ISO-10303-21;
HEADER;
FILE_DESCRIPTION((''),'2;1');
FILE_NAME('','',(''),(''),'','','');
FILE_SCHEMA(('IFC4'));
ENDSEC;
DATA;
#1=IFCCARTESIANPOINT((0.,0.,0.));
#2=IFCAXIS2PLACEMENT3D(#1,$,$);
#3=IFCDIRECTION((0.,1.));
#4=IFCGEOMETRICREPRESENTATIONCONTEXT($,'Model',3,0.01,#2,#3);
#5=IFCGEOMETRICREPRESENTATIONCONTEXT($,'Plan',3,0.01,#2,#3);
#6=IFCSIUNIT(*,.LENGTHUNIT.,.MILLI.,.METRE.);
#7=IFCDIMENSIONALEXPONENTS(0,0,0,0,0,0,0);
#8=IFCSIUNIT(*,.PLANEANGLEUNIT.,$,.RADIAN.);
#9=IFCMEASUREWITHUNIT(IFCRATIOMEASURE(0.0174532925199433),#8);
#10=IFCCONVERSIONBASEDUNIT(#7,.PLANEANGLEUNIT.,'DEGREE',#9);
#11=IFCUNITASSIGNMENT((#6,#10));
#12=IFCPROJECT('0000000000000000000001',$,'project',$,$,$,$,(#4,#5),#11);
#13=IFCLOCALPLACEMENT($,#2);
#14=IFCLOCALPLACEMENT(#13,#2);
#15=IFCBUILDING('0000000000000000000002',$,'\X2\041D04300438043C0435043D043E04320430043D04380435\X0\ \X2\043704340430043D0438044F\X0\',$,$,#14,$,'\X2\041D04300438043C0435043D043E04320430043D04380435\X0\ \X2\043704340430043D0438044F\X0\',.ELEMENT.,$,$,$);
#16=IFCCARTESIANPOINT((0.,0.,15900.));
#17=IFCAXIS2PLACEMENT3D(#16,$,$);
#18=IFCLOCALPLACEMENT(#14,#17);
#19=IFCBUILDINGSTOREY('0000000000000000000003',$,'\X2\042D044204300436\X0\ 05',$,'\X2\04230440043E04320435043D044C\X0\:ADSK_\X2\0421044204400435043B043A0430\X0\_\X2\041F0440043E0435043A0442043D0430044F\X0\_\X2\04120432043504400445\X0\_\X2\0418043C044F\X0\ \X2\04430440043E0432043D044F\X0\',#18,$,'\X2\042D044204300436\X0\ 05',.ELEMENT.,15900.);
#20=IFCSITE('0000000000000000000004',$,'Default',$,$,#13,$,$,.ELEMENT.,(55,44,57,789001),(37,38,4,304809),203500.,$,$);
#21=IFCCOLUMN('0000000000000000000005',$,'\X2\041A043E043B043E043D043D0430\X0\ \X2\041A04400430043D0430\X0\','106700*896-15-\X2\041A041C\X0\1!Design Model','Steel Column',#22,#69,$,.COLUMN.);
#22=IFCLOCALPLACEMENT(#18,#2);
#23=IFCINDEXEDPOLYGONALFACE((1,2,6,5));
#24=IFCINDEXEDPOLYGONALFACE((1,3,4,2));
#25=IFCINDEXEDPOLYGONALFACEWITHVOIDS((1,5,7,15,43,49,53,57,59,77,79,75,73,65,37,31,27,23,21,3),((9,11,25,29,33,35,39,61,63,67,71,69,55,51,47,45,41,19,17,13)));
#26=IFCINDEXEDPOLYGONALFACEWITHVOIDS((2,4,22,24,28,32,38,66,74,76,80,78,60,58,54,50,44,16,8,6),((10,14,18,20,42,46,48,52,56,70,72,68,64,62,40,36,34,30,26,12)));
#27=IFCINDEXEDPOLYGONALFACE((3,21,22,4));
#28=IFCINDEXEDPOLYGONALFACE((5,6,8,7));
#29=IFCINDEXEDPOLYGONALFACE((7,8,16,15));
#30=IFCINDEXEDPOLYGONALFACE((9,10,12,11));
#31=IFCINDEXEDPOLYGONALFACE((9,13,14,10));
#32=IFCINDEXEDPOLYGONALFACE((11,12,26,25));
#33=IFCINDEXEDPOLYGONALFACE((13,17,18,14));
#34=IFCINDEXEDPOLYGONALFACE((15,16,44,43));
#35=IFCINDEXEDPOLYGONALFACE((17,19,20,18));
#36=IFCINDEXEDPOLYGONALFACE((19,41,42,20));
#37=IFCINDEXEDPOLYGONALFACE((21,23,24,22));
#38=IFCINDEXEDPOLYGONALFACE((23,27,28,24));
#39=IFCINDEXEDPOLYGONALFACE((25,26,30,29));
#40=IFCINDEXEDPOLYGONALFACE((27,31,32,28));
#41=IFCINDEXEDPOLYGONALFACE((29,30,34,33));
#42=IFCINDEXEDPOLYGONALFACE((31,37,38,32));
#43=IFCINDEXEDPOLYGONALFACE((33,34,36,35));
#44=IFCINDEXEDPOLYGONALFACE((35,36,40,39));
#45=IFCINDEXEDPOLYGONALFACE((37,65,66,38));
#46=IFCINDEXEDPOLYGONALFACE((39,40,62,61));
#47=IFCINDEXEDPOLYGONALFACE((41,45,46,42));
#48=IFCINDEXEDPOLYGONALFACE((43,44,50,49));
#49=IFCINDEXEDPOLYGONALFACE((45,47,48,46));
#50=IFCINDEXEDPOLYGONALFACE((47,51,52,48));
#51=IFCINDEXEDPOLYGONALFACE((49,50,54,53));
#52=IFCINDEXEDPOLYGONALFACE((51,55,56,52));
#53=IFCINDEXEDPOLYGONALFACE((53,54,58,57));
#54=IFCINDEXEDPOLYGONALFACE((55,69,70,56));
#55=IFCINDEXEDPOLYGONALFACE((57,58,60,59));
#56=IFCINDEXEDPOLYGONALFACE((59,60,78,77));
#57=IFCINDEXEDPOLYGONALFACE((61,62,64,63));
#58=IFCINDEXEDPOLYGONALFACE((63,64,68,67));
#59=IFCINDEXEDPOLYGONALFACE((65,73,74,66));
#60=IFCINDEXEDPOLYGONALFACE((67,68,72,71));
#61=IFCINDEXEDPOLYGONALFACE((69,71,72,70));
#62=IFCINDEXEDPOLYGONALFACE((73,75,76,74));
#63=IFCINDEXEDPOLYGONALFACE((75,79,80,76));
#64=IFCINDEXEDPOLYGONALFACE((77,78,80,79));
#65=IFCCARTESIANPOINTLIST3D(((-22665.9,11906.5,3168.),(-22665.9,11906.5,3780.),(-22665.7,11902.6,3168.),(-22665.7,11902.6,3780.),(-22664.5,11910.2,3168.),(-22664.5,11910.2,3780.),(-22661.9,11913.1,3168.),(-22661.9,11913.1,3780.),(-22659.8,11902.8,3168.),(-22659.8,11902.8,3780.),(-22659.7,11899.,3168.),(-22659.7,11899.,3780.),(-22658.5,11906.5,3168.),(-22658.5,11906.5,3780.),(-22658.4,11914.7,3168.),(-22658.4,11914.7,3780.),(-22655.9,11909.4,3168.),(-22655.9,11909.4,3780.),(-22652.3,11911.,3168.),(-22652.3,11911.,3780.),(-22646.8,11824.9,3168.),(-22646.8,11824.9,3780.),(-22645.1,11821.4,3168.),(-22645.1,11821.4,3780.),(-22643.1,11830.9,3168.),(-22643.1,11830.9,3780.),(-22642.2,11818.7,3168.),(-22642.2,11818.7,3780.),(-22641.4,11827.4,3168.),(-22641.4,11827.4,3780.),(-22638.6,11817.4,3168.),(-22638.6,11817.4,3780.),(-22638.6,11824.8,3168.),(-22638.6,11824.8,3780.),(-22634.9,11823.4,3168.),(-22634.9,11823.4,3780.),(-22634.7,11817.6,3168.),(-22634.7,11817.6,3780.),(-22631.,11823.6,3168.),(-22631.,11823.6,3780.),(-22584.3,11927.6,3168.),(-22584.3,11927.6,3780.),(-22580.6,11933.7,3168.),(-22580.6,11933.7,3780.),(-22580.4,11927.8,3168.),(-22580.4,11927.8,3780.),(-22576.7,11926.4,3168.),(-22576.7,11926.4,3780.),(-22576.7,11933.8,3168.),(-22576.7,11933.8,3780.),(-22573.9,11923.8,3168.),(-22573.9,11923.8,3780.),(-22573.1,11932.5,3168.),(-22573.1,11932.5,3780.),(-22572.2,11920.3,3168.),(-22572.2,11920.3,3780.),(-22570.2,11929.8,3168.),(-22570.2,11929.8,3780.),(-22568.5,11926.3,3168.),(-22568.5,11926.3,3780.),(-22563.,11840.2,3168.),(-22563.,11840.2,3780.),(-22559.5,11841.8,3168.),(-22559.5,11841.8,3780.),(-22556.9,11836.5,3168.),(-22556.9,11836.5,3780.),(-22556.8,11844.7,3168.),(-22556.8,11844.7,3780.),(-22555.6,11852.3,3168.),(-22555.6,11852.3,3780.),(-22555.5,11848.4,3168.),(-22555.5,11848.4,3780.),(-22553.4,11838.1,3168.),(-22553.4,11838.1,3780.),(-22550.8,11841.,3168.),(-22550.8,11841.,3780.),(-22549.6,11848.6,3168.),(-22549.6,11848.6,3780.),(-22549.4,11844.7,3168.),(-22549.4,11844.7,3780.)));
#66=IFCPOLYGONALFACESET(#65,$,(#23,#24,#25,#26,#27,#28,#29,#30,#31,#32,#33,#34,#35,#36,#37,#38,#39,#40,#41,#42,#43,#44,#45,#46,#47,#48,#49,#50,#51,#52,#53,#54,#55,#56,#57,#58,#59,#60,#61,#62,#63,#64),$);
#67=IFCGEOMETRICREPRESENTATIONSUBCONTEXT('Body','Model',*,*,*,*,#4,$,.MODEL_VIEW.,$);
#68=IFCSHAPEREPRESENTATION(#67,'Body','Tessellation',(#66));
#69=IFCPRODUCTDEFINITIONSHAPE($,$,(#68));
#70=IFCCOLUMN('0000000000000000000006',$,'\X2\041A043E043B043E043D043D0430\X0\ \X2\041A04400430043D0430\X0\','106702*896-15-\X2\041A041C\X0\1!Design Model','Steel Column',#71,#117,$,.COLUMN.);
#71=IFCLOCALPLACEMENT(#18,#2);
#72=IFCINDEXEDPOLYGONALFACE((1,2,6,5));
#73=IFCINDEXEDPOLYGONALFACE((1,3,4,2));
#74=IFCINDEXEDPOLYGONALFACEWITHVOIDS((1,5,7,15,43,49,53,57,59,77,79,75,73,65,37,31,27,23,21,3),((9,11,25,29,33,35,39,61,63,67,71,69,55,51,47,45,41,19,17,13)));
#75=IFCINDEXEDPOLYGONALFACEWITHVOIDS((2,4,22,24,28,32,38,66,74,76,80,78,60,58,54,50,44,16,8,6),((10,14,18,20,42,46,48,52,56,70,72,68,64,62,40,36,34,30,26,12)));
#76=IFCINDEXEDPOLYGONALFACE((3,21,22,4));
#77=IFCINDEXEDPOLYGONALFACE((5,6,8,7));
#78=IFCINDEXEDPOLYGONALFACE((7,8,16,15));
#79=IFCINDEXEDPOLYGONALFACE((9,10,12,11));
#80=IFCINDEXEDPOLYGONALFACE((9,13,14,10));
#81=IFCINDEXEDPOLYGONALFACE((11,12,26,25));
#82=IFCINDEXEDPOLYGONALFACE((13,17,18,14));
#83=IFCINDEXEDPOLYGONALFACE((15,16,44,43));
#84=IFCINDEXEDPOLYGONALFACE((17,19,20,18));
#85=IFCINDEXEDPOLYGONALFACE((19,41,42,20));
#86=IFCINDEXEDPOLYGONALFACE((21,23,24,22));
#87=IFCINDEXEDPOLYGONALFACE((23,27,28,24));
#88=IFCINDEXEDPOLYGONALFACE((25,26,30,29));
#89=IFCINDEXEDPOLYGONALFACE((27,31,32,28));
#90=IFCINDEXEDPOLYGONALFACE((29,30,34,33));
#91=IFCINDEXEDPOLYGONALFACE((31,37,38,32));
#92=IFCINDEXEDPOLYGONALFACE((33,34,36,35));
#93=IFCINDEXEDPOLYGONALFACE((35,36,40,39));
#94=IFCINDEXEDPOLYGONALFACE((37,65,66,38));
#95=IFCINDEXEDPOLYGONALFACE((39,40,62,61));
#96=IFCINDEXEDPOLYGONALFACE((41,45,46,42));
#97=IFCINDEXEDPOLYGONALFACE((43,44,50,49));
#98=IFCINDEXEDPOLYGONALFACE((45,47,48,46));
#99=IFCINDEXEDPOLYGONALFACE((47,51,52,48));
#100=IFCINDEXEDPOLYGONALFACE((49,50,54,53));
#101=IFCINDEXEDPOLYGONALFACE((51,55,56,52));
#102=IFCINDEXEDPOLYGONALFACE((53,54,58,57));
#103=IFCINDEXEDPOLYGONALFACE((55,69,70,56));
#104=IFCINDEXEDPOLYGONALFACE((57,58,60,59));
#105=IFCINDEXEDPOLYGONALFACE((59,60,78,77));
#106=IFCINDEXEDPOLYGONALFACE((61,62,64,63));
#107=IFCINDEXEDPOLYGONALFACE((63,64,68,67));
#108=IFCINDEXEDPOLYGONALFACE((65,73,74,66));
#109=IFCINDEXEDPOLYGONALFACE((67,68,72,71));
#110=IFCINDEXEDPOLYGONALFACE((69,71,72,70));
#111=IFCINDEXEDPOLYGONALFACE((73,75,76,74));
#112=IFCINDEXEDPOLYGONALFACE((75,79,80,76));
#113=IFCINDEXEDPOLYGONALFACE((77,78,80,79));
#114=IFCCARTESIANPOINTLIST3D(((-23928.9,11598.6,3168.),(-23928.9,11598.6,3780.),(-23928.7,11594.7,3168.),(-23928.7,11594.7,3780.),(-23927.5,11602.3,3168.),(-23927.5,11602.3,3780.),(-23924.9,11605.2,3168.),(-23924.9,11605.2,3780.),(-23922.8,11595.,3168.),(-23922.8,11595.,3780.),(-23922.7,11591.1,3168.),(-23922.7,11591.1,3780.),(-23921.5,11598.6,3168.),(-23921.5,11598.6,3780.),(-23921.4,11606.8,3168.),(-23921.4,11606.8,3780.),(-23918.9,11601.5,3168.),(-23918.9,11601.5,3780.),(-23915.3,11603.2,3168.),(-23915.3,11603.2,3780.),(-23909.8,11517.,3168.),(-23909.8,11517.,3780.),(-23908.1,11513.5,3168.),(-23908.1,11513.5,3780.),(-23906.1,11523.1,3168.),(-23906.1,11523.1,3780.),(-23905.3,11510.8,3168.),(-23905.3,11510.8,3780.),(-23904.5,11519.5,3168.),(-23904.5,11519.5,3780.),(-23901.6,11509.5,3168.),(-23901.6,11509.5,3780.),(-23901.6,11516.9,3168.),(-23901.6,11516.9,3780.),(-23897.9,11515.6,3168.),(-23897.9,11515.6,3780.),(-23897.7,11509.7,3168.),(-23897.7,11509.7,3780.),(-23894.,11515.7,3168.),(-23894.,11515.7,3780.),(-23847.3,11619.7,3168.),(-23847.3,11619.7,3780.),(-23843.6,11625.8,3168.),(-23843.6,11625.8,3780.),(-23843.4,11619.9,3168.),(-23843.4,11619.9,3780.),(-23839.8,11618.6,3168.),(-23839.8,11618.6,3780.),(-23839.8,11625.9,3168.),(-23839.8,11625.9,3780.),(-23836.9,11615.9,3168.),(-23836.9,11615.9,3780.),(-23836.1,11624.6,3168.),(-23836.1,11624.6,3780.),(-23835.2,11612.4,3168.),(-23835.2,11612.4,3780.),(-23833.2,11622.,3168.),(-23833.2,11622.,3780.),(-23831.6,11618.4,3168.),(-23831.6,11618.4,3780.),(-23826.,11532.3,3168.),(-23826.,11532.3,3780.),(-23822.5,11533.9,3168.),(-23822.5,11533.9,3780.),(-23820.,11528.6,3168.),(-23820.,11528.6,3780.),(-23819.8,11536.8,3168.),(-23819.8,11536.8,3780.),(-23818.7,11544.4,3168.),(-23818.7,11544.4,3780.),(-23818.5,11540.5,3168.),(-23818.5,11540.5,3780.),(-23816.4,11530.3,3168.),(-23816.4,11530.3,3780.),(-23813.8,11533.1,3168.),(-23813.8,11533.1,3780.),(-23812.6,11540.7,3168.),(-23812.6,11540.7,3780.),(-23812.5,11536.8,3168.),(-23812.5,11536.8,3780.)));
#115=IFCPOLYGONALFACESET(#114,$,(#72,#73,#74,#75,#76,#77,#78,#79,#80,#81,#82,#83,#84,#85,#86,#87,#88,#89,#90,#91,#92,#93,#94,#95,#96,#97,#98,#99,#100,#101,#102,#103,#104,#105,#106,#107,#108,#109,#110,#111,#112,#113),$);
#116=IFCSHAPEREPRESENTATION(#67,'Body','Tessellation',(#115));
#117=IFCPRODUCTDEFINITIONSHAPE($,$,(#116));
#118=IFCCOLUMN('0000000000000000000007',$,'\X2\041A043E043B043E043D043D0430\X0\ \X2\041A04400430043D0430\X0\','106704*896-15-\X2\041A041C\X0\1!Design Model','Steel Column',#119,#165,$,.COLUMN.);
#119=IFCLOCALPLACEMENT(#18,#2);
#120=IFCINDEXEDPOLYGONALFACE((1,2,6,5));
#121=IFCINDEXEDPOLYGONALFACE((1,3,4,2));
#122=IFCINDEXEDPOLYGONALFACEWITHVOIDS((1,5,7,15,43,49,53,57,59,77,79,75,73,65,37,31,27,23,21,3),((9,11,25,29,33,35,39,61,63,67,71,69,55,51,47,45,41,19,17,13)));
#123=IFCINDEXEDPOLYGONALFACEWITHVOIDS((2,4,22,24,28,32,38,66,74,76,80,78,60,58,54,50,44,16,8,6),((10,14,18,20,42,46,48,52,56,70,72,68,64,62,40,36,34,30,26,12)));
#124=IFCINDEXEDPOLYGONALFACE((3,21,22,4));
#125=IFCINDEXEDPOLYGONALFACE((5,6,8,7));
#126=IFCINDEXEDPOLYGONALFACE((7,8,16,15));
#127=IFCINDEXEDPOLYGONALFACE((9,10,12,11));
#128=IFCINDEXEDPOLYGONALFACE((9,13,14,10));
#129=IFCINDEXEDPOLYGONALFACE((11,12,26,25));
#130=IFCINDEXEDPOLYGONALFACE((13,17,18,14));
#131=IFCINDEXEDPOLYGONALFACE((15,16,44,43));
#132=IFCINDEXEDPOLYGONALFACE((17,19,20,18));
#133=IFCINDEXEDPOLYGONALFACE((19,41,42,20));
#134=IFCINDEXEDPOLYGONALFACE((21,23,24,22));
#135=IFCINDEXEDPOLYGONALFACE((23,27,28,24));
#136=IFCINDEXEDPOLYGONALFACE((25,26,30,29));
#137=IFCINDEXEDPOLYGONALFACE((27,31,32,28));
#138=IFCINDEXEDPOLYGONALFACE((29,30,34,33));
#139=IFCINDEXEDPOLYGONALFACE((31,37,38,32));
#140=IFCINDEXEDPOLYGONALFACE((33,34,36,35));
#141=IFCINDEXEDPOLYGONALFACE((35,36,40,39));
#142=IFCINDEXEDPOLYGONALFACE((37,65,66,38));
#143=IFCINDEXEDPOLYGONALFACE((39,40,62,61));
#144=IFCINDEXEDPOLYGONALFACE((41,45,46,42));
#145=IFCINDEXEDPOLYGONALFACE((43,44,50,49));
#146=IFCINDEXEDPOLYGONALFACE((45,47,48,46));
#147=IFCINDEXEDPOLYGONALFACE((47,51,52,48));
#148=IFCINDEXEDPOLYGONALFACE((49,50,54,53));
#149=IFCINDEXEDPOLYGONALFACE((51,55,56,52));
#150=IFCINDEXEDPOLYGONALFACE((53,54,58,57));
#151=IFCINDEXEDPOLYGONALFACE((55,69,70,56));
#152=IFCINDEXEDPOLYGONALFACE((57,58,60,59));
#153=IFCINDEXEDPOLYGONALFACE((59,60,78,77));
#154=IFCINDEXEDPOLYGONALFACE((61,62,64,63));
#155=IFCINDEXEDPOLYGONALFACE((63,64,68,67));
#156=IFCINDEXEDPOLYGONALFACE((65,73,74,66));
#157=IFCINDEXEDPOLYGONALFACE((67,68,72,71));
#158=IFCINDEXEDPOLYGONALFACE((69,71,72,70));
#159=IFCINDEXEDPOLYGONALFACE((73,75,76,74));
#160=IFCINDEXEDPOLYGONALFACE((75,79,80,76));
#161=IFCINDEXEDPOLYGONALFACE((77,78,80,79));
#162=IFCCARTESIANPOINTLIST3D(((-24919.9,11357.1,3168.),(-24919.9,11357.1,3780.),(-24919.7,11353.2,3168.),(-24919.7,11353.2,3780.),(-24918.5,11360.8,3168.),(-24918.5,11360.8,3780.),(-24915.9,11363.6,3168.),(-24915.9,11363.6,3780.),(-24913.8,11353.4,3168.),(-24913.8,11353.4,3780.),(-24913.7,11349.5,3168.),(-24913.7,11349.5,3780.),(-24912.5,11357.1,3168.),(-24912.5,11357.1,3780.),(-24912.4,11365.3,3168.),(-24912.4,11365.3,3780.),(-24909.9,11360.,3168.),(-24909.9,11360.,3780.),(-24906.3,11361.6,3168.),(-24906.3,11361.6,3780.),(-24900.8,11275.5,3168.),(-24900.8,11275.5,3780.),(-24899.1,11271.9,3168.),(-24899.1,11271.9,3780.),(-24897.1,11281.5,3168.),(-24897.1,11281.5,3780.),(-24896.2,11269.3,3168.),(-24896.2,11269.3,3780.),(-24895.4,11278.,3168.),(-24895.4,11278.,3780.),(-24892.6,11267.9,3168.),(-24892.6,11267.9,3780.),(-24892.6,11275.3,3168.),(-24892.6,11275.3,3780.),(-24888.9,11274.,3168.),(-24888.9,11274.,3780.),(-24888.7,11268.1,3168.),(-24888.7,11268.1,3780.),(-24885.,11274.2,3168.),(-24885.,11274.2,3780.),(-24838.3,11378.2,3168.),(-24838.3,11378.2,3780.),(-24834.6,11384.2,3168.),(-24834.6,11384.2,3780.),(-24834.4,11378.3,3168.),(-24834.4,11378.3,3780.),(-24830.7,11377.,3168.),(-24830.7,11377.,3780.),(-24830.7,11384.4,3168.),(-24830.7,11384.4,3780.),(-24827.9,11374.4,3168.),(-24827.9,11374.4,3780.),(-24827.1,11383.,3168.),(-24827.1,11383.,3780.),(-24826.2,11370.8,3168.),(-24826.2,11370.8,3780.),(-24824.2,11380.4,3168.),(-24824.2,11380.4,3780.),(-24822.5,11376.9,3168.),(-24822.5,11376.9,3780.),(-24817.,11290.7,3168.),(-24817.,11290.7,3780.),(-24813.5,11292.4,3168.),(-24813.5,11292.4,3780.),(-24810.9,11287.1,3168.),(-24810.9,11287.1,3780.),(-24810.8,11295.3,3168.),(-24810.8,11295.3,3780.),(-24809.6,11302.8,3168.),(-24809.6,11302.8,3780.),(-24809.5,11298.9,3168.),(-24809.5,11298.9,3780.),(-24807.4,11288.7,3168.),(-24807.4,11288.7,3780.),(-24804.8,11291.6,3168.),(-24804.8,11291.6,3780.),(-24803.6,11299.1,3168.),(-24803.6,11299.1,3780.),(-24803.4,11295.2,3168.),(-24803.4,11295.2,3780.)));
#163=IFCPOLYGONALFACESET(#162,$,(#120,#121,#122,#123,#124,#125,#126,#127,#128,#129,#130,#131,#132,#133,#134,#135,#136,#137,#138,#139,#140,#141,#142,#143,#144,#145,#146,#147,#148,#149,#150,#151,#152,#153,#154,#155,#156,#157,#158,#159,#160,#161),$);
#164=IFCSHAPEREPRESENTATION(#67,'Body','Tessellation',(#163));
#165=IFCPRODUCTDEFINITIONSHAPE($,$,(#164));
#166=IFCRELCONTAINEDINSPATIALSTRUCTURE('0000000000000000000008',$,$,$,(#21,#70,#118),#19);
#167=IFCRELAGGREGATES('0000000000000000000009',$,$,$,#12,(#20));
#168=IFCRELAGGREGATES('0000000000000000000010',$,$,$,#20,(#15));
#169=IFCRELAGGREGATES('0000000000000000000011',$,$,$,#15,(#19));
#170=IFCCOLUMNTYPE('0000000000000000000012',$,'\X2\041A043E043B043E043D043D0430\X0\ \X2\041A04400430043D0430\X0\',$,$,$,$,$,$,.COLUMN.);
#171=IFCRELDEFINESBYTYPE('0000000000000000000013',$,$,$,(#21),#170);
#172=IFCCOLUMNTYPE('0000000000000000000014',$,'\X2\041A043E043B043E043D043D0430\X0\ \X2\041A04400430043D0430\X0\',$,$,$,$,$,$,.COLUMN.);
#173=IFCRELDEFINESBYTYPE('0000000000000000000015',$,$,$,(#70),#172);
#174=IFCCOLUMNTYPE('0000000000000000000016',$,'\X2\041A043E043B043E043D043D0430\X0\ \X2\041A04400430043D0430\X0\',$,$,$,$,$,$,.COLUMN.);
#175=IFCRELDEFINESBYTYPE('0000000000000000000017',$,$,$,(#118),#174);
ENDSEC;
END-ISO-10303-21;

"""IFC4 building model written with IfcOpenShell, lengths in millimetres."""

from ifc_helpers import new_model, entity, si_unit, converted_unit, direction, frame, origin, place, context, subcontext, project, spatial, indexed_curve, outline, extrude, type_object, element, save


model = new_model("IFC4")

# Units and contexts
model_context = context("Model", 3, precision=0.01, world=origin(), true_north=direction((0.0, 1.0)))
plan_context = context("Plan", 3, precision=0.01, world=origin(), true_north=direction((0.0, 1.0)))
body_context = subcontext(model_context, "Body", "Model", "MODEL_VIEW")
ifc_project = project(units=[si_unit("LENGTHUNIT", "METRE", prefix="MILLI"), converted_unit("PLANEANGLEUNIT", "DEGREE", entity("IfcRatioMeasure", 0.0174532925199433), si_unit("PLANEANGLEUNIT", "RADIAN"), dimensions=[0, 0, 0, 0, 0, 0, 0])], contexts=[model_context, plan_context])

# Site, building, storey
site_placement = place(None, origin())
site = spatial("IfcSite", under=ifc_project, at=site_placement, Name="Default", CompositionType="ELEMENT", RefLatitude=(55, 44, 57, 789001), RefLongitude=(37, 38, 4, 304809), RefElevation=203500.0)
building_placement = place(site_placement, origin())
building = spatial("IfcBuilding", under=site, at=building_placement, Name="Наименование здания", LongName="Наименование здания", CompositionType="ELEMENT")
storey_placement = place(building_placement, frame((0.0, 0.0, 15900.0)))
storey = spatial("IfcBuildingStorey", under=building, at=storey_placement, Name="Этаж 05", ObjectType="Уровень:ADSK_Стрелка_Проектная_Вверх_Имя уровня", LongName="Этаж 05", CompositionType="ELEMENT", Elevation=15900.0)

# Columns
column_type_1 = type_object("IfcColumnType", Name="Колонна Крана", PredefinedType="COLUMN")
column_1_placement = place(storey_placement, origin())
element("IfcColumn", 1, at=column_1_placement, inside=storey, type_object=column_type_1, Name="Колонна Крана", Description="106700*896-15-КМ1!Design Model", ObjectType="Steel Column", PredefinedType="COLUMN", context=body_context, shape_type="SweptSolid", body=[
    extrude(outline(indexed_curve([(29.5, -56.8), (33.4, -56.8), (37.0, -55.3), (39.7, -52.6), (41.2, -49.0), (56.8, 29.5), (56.8, 33.4), (55.3, 37.0), (52.6, 39.7), (49.0, 41.2), (-29.5, 56.8), (-33.4, 56.8), (-37.0, 55.3), (-39.7, 52.6), (-41.2, 49.0), (-56.8, -29.5), (-56.8, -33.4), (-55.3, -37.0), (-52.6, -39.7), (-49.0, -41.2), (29.5, -56.8)], self_intersect=False), holes=[indexed_curve([(-43.1, -37.3), (-46.7, -35.8), (-49.5, -33.1), (-51.0, -29.5), (-51.0, -25.5), (-37.3, 43.1), (-35.8, 46.7), (-33.1, 49.5), (-29.5, 51.0), (-25.5, 51.0), (43.1, 37.3), (46.7, 35.8), (49.5, 33.1), (51.0, 29.5), (51.0, 25.5), (37.3, -43.1), (35.8, -46.7), (33.1, -49.5), (29.5, -51.0), (25.5, -51.0), (-43.1, -37.3)], self_intersect=False)]), frame((-22607.7, 11875.6, 3168.0), z_axis=(0.0, 0.0, 1.0), x_axis=(-0.906681, -0.421816, 0.0)), (0.0, 0.0, 1.0), 612.0),
])
column_type_2 = type_object("IfcColumnType", Name="Колонна Крана", PredefinedType="COLUMN")
column_2_placement = place(storey_placement, origin())
element("IfcColumn", 2, at=column_2_placement, inside=storey, type_object=column_type_2, Name="Колонна Крана", Description="106702*896-15-КМ1!Design Model", ObjectType="Steel Column", PredefinedType="COLUMN", context=body_context, shape_type="SweptSolid", body=[
    extrude(outline(indexed_curve([(29.5, -56.8), (33.4, -56.8), (37.0, -55.3), (39.7, -52.6), (41.2, -49.0), (56.8, 29.5), (56.8, 33.4), (55.3, 37.0), (52.6, 39.7), (49.0, 41.2), (-29.5, 56.8), (-33.4, 56.8), (-37.0, 55.3), (-39.7, 52.6), (-41.2, 49.0), (-56.8, -29.5), (-56.8, -33.4), (-55.3, -37.0), (-52.6, -39.7), (-49.0, -41.2), (29.5, -56.8)], self_intersect=False), holes=[indexed_curve([(-43.1, -37.3), (-46.7, -35.8), (-49.5, -33.1), (-51.0, -29.5), (-51.0, -25.5), (-37.3, 43.1), (-35.8, 46.7), (-33.1, 49.5), (-29.5, 51.0), (-25.5, 51.0), (43.1, 37.3), (46.7, 35.8), (49.5, 33.1), (51.0, 29.5), (51.0, 25.5), (37.3, -43.1), (35.8, -46.7), (33.1, -49.5), (29.5, -51.0), (25.5, -51.0), (-43.1, -37.3)], self_intersect=False)]), frame((-23870.7, 11567.7, 3168.0), z_axis=(0.0, 0.0, 1.0), x_axis=(-0.906681, -0.421816, 0.0)), (0.0, 0.0, 1.0), 612.0),
])
column_type_3 = type_object("IfcColumnType", Name="Колонна Крана", PredefinedType="COLUMN")
column_3_placement = place(storey_placement, origin())
element("IfcColumn", 3, at=column_3_placement, inside=storey, type_object=column_type_3, Name="Колонна Крана", Description="106704*896-15-КМ1!Design Model", ObjectType="Steel Column", PredefinedType="COLUMN", context=body_context, shape_type="SweptSolid", body=[
    extrude(outline(indexed_curve([(29.5, -56.8), (33.4, -56.8), (37.0, -55.3), (39.7, -52.6), (41.2, -49.0), (56.8, 29.5), (56.8, 33.4), (55.3, 37.0), (52.6, 39.7), (49.0, 41.2), (-29.5, 56.8), (-33.4, 56.8), (-37.0, 55.3), (-39.7, 52.6), (-41.2, 49.0), (-56.8, -29.5), (-56.8, -33.4), (-55.3, -37.0), (-52.6, -39.7), (-49.0, -41.2), (29.5, -56.8)], self_intersect=False), holes=[indexed_curve([(-43.1, -37.3), (-46.7, -35.8), (-49.5, -33.1), (-51.0, -29.5), (-51.0, -25.5), (-37.3, 43.1), (-35.8, 46.7), (-33.1, 49.5), (-29.5, 51.0), (-25.5, 51.0), (43.1, 37.3), (46.7, 35.8), (49.5, 33.1), (51.0, 29.5), (51.0, 25.5), (37.3, -43.1), (35.8, -46.7), (33.1, -49.5), (29.5, -51.0), (25.5, -51.0), (-43.1, -37.3)], self_intersect=False)]), frame((-24861.7, 11326.2, 3168.0), z_axis=(0.0, 0.0, 1.0), x_axis=(-0.906681, -0.421816, 0.0)), (0.0, 0.0, 1.0), 612.0),
])

save(model, "model.ifc")
